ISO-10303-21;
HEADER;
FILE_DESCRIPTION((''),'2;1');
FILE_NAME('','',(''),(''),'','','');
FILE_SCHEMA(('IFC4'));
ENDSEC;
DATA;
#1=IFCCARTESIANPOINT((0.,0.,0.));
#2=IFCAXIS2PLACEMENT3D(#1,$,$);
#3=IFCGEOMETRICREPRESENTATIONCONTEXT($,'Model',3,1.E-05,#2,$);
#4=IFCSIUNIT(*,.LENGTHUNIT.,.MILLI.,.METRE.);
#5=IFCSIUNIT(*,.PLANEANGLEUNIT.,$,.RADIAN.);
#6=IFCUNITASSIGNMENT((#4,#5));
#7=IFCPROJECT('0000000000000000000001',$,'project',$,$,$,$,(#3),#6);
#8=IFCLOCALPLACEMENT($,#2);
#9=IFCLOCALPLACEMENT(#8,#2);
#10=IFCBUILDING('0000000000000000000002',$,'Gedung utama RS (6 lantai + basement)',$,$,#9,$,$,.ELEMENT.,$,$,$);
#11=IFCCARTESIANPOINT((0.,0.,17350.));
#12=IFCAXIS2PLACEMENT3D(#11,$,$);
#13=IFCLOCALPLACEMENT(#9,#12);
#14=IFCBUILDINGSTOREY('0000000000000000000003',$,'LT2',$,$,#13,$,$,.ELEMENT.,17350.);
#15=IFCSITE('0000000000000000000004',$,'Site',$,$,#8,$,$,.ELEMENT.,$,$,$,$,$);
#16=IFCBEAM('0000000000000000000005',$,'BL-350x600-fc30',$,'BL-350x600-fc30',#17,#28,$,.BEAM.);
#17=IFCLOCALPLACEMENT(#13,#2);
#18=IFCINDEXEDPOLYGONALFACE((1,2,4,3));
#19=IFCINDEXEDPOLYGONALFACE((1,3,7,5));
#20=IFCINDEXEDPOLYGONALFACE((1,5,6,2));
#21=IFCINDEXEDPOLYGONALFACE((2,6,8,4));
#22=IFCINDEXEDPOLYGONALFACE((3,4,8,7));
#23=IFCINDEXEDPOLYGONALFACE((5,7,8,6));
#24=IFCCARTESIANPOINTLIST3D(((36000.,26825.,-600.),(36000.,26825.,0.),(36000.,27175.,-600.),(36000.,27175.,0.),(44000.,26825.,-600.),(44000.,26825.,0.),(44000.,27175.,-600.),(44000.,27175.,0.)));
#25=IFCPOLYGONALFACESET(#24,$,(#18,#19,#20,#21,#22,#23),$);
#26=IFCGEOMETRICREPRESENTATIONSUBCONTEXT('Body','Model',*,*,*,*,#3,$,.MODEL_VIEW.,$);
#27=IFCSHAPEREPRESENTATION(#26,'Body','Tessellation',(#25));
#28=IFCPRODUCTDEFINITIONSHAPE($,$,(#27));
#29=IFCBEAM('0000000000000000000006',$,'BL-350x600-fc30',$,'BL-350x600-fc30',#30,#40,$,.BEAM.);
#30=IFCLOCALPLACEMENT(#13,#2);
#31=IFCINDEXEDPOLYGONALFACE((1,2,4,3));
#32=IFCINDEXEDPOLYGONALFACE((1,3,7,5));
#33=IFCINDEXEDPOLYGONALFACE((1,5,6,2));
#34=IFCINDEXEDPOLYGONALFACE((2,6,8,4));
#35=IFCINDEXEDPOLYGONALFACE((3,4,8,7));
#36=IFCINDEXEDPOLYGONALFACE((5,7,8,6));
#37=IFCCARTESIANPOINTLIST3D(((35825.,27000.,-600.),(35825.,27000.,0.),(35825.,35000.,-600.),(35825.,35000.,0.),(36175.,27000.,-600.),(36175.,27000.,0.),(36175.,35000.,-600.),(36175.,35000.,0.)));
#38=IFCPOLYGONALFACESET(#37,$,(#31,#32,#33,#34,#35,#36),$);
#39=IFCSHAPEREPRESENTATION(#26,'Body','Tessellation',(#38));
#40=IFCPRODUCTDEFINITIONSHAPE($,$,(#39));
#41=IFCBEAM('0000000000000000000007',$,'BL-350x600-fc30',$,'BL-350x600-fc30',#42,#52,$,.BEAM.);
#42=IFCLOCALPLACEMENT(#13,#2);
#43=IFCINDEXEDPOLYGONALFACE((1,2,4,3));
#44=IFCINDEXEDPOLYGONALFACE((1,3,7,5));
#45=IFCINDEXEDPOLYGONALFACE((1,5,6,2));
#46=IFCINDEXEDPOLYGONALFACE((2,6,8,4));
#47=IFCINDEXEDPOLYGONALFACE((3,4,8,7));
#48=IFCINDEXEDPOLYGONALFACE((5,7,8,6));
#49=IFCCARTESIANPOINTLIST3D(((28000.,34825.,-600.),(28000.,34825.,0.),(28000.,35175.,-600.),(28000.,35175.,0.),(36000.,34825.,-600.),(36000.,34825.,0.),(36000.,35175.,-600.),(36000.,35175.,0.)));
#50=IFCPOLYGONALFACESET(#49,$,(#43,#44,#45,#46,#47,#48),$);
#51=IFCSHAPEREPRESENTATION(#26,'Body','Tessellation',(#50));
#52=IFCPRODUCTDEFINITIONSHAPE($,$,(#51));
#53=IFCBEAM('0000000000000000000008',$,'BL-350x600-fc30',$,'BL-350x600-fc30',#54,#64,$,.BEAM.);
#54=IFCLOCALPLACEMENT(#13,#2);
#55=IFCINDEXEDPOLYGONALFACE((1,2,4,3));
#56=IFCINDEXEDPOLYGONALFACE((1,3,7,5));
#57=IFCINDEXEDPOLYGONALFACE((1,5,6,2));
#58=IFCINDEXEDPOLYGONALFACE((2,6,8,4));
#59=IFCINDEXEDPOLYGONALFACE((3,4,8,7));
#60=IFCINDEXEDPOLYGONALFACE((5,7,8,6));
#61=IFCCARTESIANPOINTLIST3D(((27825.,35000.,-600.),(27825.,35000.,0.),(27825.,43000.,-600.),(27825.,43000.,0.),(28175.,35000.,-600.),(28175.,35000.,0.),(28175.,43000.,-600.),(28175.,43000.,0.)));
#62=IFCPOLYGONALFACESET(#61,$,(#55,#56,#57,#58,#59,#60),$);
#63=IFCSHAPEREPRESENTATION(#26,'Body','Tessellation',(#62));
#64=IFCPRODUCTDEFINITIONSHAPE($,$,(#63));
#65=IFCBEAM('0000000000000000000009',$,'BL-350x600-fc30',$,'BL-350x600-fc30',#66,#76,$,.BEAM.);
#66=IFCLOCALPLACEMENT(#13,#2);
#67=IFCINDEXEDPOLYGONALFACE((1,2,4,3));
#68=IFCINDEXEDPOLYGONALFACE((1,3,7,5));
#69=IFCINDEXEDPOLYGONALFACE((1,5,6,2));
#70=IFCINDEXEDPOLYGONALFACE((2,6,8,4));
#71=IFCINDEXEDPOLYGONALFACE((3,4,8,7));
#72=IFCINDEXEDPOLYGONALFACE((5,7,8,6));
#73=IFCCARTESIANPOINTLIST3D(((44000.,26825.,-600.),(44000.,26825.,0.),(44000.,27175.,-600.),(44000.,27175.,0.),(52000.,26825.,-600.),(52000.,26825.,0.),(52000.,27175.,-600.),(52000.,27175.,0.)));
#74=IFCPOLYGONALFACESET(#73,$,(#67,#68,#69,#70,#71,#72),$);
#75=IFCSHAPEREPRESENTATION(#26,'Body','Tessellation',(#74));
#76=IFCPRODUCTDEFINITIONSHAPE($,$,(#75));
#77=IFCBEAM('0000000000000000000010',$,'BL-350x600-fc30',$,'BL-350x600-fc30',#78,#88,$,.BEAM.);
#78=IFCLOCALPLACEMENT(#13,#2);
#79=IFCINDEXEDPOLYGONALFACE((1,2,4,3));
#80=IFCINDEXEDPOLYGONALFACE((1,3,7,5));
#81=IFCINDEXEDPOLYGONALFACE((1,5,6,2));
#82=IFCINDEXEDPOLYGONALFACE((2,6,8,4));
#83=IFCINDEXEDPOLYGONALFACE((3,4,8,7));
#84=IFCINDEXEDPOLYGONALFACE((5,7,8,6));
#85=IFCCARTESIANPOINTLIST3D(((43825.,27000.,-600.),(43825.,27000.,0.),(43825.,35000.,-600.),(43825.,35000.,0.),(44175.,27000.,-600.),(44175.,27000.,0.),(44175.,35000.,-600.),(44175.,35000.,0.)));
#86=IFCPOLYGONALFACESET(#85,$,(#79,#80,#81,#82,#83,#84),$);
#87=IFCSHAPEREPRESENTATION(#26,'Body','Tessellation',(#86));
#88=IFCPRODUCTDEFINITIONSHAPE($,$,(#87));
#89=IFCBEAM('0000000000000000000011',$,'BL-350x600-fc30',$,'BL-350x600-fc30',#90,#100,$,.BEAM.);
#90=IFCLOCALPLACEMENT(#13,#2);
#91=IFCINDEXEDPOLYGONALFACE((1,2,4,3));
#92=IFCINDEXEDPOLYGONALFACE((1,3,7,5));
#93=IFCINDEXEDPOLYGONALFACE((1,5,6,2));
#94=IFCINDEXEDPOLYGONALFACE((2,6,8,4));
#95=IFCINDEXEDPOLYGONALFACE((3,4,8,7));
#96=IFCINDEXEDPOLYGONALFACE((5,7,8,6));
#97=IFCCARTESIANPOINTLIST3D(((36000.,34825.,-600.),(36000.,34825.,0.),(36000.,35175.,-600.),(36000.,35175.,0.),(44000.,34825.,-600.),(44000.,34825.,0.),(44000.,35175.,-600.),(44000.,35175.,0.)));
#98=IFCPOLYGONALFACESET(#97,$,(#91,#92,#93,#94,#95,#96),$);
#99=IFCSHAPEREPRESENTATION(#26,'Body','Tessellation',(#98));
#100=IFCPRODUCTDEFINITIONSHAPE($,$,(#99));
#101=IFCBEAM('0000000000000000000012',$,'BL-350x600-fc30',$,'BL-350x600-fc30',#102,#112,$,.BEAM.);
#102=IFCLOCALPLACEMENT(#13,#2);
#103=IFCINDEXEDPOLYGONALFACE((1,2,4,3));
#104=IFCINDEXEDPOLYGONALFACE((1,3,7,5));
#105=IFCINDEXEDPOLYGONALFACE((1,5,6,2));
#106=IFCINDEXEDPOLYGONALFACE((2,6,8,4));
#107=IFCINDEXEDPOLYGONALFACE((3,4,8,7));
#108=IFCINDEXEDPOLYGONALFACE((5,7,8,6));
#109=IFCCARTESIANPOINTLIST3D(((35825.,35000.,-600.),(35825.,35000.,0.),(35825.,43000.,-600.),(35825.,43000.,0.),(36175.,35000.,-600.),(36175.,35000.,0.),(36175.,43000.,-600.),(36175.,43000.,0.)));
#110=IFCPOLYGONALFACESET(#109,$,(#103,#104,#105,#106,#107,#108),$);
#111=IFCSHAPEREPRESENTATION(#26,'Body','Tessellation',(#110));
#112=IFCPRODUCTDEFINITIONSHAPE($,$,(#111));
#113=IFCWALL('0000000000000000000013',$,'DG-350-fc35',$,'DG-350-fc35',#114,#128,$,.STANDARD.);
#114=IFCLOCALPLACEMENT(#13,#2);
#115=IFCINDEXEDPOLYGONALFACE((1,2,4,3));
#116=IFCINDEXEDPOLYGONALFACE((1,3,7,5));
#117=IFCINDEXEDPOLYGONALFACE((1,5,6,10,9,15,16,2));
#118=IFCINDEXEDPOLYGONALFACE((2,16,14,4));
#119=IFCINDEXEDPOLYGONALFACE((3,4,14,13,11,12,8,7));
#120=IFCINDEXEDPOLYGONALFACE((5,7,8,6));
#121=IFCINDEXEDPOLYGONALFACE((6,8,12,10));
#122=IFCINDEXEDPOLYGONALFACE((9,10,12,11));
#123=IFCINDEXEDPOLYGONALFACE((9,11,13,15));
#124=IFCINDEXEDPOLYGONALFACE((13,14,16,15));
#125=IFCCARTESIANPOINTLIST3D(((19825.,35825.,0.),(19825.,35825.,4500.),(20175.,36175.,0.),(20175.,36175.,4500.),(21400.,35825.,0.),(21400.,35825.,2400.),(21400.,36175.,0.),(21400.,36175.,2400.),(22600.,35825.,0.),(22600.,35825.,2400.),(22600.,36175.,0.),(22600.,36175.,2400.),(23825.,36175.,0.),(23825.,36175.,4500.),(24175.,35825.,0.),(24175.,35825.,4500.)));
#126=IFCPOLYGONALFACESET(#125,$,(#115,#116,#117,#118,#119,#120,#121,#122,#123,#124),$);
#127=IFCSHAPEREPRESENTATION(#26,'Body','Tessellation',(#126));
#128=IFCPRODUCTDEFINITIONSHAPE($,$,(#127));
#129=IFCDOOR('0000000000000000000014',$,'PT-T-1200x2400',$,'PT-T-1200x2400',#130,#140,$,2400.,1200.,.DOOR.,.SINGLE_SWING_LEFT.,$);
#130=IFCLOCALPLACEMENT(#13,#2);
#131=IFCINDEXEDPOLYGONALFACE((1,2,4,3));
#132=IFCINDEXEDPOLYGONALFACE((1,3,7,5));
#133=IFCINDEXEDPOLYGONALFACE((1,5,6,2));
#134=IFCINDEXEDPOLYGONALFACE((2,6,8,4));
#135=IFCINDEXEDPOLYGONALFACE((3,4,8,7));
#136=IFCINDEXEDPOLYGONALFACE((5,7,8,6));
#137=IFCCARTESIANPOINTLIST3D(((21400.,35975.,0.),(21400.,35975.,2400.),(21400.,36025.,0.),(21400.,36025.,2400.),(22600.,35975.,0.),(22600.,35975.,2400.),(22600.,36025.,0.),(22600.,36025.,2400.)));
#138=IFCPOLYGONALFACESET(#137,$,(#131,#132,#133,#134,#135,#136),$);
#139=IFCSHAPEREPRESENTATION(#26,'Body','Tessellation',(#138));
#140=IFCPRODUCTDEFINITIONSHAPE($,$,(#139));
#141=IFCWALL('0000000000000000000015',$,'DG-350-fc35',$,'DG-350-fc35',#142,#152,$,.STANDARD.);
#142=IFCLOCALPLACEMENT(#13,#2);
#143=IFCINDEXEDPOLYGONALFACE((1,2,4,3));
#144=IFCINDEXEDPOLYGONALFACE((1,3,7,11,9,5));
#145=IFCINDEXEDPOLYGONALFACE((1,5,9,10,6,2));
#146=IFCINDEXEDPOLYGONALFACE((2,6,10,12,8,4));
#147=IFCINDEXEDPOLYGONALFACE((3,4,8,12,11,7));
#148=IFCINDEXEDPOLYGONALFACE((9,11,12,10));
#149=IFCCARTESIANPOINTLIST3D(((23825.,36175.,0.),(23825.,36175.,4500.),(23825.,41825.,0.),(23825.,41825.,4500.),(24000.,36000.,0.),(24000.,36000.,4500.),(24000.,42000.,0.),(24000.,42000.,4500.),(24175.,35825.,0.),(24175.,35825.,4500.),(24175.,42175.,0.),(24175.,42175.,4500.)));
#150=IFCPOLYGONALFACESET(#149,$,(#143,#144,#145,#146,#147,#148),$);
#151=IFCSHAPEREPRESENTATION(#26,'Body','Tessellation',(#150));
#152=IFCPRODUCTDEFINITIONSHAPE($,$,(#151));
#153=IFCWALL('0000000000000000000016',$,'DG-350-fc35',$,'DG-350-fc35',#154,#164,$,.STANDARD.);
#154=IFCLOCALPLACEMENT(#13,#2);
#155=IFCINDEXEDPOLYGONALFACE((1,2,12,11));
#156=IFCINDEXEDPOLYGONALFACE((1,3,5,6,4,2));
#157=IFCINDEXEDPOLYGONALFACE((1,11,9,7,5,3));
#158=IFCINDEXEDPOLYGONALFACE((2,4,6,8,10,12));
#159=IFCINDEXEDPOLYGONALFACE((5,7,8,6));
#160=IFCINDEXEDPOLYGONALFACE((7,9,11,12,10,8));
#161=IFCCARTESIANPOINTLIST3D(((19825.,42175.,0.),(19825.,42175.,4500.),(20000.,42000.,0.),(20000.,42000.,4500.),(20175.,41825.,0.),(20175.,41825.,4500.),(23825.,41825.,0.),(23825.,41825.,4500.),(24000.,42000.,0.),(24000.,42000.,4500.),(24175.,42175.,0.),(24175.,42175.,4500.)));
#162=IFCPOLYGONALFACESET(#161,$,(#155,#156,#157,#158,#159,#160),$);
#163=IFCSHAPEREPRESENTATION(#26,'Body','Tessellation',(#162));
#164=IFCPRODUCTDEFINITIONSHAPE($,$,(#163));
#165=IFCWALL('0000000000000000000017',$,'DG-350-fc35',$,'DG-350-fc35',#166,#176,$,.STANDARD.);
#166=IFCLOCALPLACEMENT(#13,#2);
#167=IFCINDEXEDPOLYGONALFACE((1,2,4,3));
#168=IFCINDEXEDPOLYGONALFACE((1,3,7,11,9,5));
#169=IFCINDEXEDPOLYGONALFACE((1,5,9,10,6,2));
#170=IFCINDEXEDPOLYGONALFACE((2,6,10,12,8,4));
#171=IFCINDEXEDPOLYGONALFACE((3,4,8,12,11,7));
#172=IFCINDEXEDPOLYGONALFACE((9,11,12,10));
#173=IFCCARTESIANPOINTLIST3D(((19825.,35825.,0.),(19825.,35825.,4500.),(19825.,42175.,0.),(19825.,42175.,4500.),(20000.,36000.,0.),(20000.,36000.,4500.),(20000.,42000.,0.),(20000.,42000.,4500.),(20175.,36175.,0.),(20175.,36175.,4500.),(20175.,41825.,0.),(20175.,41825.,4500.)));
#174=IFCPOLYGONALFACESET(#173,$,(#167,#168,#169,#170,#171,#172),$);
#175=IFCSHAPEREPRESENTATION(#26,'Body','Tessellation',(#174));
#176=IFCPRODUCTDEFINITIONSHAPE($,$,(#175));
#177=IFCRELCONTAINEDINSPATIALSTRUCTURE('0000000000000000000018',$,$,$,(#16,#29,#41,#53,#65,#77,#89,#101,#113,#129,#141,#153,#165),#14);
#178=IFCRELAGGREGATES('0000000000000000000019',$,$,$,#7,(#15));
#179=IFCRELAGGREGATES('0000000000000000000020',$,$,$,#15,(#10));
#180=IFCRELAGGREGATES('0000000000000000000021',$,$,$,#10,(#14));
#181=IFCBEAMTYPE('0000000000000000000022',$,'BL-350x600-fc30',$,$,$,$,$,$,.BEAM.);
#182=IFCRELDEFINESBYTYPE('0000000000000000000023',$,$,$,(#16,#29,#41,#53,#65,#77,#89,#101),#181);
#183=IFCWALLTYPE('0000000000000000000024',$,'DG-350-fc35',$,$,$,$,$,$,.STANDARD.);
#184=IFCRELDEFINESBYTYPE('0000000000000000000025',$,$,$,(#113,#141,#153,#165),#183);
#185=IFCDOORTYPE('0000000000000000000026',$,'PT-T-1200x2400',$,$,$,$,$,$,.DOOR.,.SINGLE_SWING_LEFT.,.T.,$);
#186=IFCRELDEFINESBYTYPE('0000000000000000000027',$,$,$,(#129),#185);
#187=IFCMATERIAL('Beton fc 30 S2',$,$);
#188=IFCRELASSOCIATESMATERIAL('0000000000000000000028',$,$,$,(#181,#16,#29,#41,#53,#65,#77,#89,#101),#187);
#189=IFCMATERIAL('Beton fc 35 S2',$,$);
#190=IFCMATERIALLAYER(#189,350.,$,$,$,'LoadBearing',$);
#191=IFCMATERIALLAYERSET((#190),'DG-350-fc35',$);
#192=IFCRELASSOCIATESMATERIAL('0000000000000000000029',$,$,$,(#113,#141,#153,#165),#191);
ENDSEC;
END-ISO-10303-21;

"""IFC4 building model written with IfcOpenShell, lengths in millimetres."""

from ifc_helpers import new_model, si_unit, frame, frame_2d, origin, origin_2d, place, context, subcontext, project, spatial, polyline, rectangle, outline, extrude, material, layer, layer_set, layer_usage, material_profile, profile_set, profile_usage, type_object, element, fill, save


model = new_model("IFC4")

# Units and contexts
model_context = context("Model", 3, precision=1e-05, world=origin())
body_context = subcontext(model_context, "Body", "Model", "MODEL_VIEW")
ifc_project = project(units=[si_unit("LENGTHUNIT", "METRE", prefix="MILLI"), si_unit("PLANEANGLEUNIT", "RADIAN")], contexts=[model_context])

# Site, building, storey
site_placement = place(None, origin())
site = spatial("IfcSite", under=ifc_project, at=site_placement, Name="Site", CompositionType="ELEMENT")
building_placement = place(site_placement, origin())
building = spatial("IfcBuilding", under=site, at=building_placement, Name="Gedung utama RS (6 lantai + basement)", CompositionType="ELEMENT")
storey_placement = place(building_placement, frame((0.0, 0.0, 17350.0)))
storey = spatial("IfcBuildingStorey", under=building, at=storey_placement, Name="LT2", CompositionType="ELEMENT", Elevation=17350.0)

# Beams
ifc_material_1 = material(Name="Beton fc 30 S2")
ifc_material_profile_1 = material_profile(ifc_material_1, rectangle(XDim=350.0, YDim=600.0, at=origin_2d()), Name="BL-350x600-fc30")
ifc_profile_set_1 = profile_set([ifc_material_profile_1], Name="BL-350x600-fc30")
ifc_profile_usage_1 = profile_usage(ifc_profile_set_1, cardinal=8)
beam_type = type_object("IfcBeamType", Name="BL-350x600-fc30", PredefinedType="BEAM", material=ifc_profile_set_1)
beam_1_placement = place(storey_placement, frame((36000.0, 27000.0, -300.0)))
element("IfcBeam", 1, at=beam_1_placement, inside=storey, type_object=beam_type, material=ifc_profile_usage_1, Name="BL-350x600-fc30", ObjectType="BL-350x600-fc30", PredefinedType="BEAM", context=body_context, shape_type="SweptSolid", body=[
    extrude(rectangle(XDim=350.0, YDim=600.0, at=origin_2d()), frame((0.0, 0.0, 0.0), z_axis=(1.0, 0.0, 0.0), x_axis=(0.0, 1.0, 0.0)), (0.0, 0.0, 1.0), 8000.0),
])
beam_2_placement = place(storey_placement, frame((36000.0, 27000.0, -300.0)))
element("IfcBeam", 2, at=beam_2_placement, inside=storey, type_object=beam_type, material=ifc_profile_usage_1, Name="BL-350x600-fc30", ObjectType="BL-350x600-fc30", PredefinedType="BEAM", context=body_context, shape_type="SweptSolid", body=[
    extrude(rectangle(XDim=350.0, YDim=600.0, at=origin_2d()), frame((0.0, 0.0, 0.0), z_axis=(0.0, 1.0, 0.0), x_axis=(-1.0, 0.0, 0.0)), (0.0, 0.0, 1.0), 8000.0),
])
beam_3_placement = place(storey_placement, frame((28000.0, 35000.0, -300.0)))
element("IfcBeam", 3, at=beam_3_placement, inside=storey, type_object=beam_type, material=ifc_profile_usage_1, Name="BL-350x600-fc30", ObjectType="BL-350x600-fc30", PredefinedType="BEAM", context=body_context, shape_type="SweptSolid", body=[
    extrude(rectangle(XDim=350.0, YDim=600.0, at=origin_2d()), frame((0.0, 0.0, 0.0), z_axis=(1.0, 0.0, 0.0), x_axis=(0.0, 1.0, 0.0)), (0.0, 0.0, 1.0), 8000.0),
])
beam_4_placement = place(storey_placement, frame((28000.0, 35000.0, -300.0)))
element("IfcBeam", 4, at=beam_4_placement, inside=storey, type_object=beam_type, material=ifc_profile_usage_1, Name="BL-350x600-fc30", ObjectType="BL-350x600-fc30", PredefinedType="BEAM", context=body_context, shape_type="SweptSolid", body=[
    extrude(rectangle(XDim=350.0, YDim=600.0, at=origin_2d()), frame((0.0, 0.0, 0.0), z_axis=(0.0, 1.0, 0.0), x_axis=(-1.0, 0.0, 0.0)), (0.0, 0.0, 1.0), 8000.0),
])
beam_5_placement = place(storey_placement, frame((44000.0, 27000.0, -300.0)))
element("IfcBeam", 5, at=beam_5_placement, inside=storey, type_object=beam_type, material=ifc_profile_usage_1, Name="BL-350x600-fc30", ObjectType="BL-350x600-fc30", PredefinedType="BEAM", context=body_context, shape_type="SweptSolid", body=[
    extrude(rectangle(XDim=350.0, YDim=600.0, at=origin_2d()), frame((0.0, 0.0, 0.0), z_axis=(1.0, 0.0, 0.0), x_axis=(0.0, 1.0, 0.0)), (0.0, 0.0, 1.0), 8000.0),
])
beam_6_placement = place(storey_placement, frame((44000.0, 27000.0, -300.0)))
element("IfcBeam", 6, at=beam_6_placement, inside=storey, type_object=beam_type, material=ifc_profile_usage_1, Name="BL-350x600-fc30", ObjectType="BL-350x600-fc30", PredefinedType="BEAM", context=body_context, shape_type="SweptSolid", body=[
    extrude(rectangle(XDim=350.0, YDim=600.0, at=origin_2d()), frame((0.0, 0.0, 0.0), z_axis=(0.0, 1.0, 0.0), x_axis=(-1.0, 0.0, 0.0)), (0.0, 0.0, 1.0), 8000.0),
])
beam_7_placement = place(storey_placement, frame((36000.0, 35000.0, -300.0)))
element("IfcBeam", 7, at=beam_7_placement, inside=storey, type_object=beam_type, material=ifc_profile_usage_1, Name="BL-350x600-fc30", ObjectType="BL-350x600-fc30", PredefinedType="BEAM", context=body_context, shape_type="SweptSolid", body=[
    extrude(rectangle(XDim=350.0, YDim=600.0, at=origin_2d()), frame((0.0, 0.0, 0.0), z_axis=(1.0, 0.0, 0.0), x_axis=(0.0, 1.0, 0.0)), (0.0, 0.0, 1.0), 8000.0),
])
beam_8_placement = place(storey_placement, frame((36000.0, 35000.0, -300.0)))
element("IfcBeam", 8, at=beam_8_placement, inside=storey, type_object=beam_type, material=ifc_profile_usage_1, Name="BL-350x600-fc30", ObjectType="BL-350x600-fc30", PredefinedType="BEAM", context=body_context, shape_type="SweptSolid", body=[
    extrude(rectangle(XDim=350.0, YDim=600.0, at=origin_2d()), frame((0.0, 0.0, 0.0), z_axis=(0.0, 1.0, 0.0), x_axis=(-1.0, 0.0, 0.0)), (0.0, 0.0, 1.0), 8000.0),
])

# Wall, opening, door
ifc_material_2 = material(Name="Beton fc 35 S2")
ifc_layer = layer(ifc_material_2, 350.0, Category="LoadBearing")
ifc_layer_set = layer_set([ifc_layer], Name="DG-350-fc35")
ifc_layer_usage = layer_usage(ifc_layer_set, "AXIS2", "NEGATIVE", 175.0)
wall_type = type_object("IfcWallType", Name="DG-350-fc35", PredefinedType="STANDARD")
wall_1_placement = place(storey_placement, frame((20000.0, 36000.0, 0.0), z_axis=(0.0, 0.0, 1.0), x_axis=(1.0, 0.0, 0.0)))
wall_1 = element("IfcWall", 9, at=wall_1_placement, inside=storey, type_object=wall_type, material=ifc_layer_usage, Name="DG-350-fc35", ObjectType="DG-350-fc35", PredefinedType="STANDARD", context=body_context, shape_type="SweptSolid", body=[
    extrude(outline(polyline([(-175.0, -175.0), (0.0, 0.0), (175.0, 175.0), (3825.0, 175.0), (4000.0, 0.0), (4175.0, -175.0), (-175.0, -175.0)])), origin(), (0.0, 0.0, 1.0), 4500.0),
])
opening_placement = place(wall_1_placement, frame((1400.0, 0.0, 0.0), z_axis=(0.0, 0.0, 1.0), x_axis=(1.0, 0.0, 0.0)))
opening = element("IfcOpeningElement", 10, at=opening_placement, cuts=wall_1, PredefinedType="OPENING", context=body_context, shape_type="SweptSolid", body=[
    extrude(rectangle(XDim=1200.0, YDim=370.0, at=frame_2d((600.0, 0.0))), origin(), (0.0, 0.0, 1.0), 2400.0),
])
door_type = type_object("IfcDoorType", Name="PT-T-1200x2400", OperationType="SINGLE_SWING_LEFT", ParameterTakesPrecedence=True, PredefinedType="DOOR")
door_placement = place(opening_placement, origin())
door = element("IfcDoor", 11, at=door_placement, inside=storey, type_object=door_type, Name="PT-T-1200x2400", ObjectType="PT-T-1200x2400", OperationType="SINGLE_SWING_LEFT", OverallHeight=2400.0, OverallWidth=1200.0, PredefinedType="DOOR", context=body_context, shape_type="SweptSolid", body=[
    extrude(rectangle(XDim=1200.0, YDim=50.0, at=frame_2d((600.0, 0.0))), origin(), (0.0, 0.0, 1.0), 2400.0),
])
fill(opening, door)

# Walls
wall_2_placement = place(storey_placement, frame((24000.0, 36000.0, 0.0), z_axis=(0.0, 0.0, 1.0), x_axis=(0.0, 1.0, 0.0)))
element("IfcWall", 12, at=wall_2_placement, inside=storey, type_object=wall_type, material=ifc_layer_usage, Name="DG-350-fc35", ObjectType="DG-350-fc35", PredefinedType="STANDARD", context=body_context, shape_type="SweptSolid", body=[
    extrude(outline(polyline([(-175.0, -175.0), (0.0, 0.0), (175.0, 175.0), (5825.0, 175.0), (6000.0, 0.0), (6175.0, -175.0), (-175.0, -175.0)])), origin(), (0.0, 0.0, 1.0), 4500.0),
])
wall_3_placement = place(storey_placement, frame((24000.0, 42000.0, 0.0), z_axis=(0.0, 0.0, 1.0), x_axis=(-1.0, 0.0, 0.0)))
element("IfcWall", 13, at=wall_3_placement, inside=storey, type_object=wall_type, material=ifc_layer_usage, Name="DG-350-fc35", ObjectType="DG-350-fc35", PredefinedType="STANDARD", context=body_context, shape_type="SweptSolid", body=[
    extrude(outline(polyline([(-175.0, -175.0), (0.0, 0.0), (175.0, 175.0), (3825.0, 175.0), (4000.0, 0.0), (4175.0, -175.0), (-175.0, -175.0)])), origin(), (0.0, 0.0, 1.0), 4500.0),
])
wall_4_placement = place(storey_placement, frame((20000.0, 42000.0, 0.0), z_axis=(0.0, 0.0, 1.0), x_axis=(0.0, -1.0, 0.0)))
element("IfcWall", 14, at=wall_4_placement, inside=storey, type_object=wall_type, material=ifc_layer_usage, Name="DG-350-fc35", ObjectType="DG-350-fc35", PredefinedType="STANDARD", context=body_context, shape_type="SweptSolid", body=[
    extrude(outline(polyline([(-175.0, -175.0), (0.0, 0.0), (175.0, 175.0), (5825.0, 175.0), (6000.0, 0.0), (6175.0, -175.0), (-175.0, -175.0)])), origin(), (0.0, 0.0, 1.0), 4500.0),
])

save(model, "model.ifc")
